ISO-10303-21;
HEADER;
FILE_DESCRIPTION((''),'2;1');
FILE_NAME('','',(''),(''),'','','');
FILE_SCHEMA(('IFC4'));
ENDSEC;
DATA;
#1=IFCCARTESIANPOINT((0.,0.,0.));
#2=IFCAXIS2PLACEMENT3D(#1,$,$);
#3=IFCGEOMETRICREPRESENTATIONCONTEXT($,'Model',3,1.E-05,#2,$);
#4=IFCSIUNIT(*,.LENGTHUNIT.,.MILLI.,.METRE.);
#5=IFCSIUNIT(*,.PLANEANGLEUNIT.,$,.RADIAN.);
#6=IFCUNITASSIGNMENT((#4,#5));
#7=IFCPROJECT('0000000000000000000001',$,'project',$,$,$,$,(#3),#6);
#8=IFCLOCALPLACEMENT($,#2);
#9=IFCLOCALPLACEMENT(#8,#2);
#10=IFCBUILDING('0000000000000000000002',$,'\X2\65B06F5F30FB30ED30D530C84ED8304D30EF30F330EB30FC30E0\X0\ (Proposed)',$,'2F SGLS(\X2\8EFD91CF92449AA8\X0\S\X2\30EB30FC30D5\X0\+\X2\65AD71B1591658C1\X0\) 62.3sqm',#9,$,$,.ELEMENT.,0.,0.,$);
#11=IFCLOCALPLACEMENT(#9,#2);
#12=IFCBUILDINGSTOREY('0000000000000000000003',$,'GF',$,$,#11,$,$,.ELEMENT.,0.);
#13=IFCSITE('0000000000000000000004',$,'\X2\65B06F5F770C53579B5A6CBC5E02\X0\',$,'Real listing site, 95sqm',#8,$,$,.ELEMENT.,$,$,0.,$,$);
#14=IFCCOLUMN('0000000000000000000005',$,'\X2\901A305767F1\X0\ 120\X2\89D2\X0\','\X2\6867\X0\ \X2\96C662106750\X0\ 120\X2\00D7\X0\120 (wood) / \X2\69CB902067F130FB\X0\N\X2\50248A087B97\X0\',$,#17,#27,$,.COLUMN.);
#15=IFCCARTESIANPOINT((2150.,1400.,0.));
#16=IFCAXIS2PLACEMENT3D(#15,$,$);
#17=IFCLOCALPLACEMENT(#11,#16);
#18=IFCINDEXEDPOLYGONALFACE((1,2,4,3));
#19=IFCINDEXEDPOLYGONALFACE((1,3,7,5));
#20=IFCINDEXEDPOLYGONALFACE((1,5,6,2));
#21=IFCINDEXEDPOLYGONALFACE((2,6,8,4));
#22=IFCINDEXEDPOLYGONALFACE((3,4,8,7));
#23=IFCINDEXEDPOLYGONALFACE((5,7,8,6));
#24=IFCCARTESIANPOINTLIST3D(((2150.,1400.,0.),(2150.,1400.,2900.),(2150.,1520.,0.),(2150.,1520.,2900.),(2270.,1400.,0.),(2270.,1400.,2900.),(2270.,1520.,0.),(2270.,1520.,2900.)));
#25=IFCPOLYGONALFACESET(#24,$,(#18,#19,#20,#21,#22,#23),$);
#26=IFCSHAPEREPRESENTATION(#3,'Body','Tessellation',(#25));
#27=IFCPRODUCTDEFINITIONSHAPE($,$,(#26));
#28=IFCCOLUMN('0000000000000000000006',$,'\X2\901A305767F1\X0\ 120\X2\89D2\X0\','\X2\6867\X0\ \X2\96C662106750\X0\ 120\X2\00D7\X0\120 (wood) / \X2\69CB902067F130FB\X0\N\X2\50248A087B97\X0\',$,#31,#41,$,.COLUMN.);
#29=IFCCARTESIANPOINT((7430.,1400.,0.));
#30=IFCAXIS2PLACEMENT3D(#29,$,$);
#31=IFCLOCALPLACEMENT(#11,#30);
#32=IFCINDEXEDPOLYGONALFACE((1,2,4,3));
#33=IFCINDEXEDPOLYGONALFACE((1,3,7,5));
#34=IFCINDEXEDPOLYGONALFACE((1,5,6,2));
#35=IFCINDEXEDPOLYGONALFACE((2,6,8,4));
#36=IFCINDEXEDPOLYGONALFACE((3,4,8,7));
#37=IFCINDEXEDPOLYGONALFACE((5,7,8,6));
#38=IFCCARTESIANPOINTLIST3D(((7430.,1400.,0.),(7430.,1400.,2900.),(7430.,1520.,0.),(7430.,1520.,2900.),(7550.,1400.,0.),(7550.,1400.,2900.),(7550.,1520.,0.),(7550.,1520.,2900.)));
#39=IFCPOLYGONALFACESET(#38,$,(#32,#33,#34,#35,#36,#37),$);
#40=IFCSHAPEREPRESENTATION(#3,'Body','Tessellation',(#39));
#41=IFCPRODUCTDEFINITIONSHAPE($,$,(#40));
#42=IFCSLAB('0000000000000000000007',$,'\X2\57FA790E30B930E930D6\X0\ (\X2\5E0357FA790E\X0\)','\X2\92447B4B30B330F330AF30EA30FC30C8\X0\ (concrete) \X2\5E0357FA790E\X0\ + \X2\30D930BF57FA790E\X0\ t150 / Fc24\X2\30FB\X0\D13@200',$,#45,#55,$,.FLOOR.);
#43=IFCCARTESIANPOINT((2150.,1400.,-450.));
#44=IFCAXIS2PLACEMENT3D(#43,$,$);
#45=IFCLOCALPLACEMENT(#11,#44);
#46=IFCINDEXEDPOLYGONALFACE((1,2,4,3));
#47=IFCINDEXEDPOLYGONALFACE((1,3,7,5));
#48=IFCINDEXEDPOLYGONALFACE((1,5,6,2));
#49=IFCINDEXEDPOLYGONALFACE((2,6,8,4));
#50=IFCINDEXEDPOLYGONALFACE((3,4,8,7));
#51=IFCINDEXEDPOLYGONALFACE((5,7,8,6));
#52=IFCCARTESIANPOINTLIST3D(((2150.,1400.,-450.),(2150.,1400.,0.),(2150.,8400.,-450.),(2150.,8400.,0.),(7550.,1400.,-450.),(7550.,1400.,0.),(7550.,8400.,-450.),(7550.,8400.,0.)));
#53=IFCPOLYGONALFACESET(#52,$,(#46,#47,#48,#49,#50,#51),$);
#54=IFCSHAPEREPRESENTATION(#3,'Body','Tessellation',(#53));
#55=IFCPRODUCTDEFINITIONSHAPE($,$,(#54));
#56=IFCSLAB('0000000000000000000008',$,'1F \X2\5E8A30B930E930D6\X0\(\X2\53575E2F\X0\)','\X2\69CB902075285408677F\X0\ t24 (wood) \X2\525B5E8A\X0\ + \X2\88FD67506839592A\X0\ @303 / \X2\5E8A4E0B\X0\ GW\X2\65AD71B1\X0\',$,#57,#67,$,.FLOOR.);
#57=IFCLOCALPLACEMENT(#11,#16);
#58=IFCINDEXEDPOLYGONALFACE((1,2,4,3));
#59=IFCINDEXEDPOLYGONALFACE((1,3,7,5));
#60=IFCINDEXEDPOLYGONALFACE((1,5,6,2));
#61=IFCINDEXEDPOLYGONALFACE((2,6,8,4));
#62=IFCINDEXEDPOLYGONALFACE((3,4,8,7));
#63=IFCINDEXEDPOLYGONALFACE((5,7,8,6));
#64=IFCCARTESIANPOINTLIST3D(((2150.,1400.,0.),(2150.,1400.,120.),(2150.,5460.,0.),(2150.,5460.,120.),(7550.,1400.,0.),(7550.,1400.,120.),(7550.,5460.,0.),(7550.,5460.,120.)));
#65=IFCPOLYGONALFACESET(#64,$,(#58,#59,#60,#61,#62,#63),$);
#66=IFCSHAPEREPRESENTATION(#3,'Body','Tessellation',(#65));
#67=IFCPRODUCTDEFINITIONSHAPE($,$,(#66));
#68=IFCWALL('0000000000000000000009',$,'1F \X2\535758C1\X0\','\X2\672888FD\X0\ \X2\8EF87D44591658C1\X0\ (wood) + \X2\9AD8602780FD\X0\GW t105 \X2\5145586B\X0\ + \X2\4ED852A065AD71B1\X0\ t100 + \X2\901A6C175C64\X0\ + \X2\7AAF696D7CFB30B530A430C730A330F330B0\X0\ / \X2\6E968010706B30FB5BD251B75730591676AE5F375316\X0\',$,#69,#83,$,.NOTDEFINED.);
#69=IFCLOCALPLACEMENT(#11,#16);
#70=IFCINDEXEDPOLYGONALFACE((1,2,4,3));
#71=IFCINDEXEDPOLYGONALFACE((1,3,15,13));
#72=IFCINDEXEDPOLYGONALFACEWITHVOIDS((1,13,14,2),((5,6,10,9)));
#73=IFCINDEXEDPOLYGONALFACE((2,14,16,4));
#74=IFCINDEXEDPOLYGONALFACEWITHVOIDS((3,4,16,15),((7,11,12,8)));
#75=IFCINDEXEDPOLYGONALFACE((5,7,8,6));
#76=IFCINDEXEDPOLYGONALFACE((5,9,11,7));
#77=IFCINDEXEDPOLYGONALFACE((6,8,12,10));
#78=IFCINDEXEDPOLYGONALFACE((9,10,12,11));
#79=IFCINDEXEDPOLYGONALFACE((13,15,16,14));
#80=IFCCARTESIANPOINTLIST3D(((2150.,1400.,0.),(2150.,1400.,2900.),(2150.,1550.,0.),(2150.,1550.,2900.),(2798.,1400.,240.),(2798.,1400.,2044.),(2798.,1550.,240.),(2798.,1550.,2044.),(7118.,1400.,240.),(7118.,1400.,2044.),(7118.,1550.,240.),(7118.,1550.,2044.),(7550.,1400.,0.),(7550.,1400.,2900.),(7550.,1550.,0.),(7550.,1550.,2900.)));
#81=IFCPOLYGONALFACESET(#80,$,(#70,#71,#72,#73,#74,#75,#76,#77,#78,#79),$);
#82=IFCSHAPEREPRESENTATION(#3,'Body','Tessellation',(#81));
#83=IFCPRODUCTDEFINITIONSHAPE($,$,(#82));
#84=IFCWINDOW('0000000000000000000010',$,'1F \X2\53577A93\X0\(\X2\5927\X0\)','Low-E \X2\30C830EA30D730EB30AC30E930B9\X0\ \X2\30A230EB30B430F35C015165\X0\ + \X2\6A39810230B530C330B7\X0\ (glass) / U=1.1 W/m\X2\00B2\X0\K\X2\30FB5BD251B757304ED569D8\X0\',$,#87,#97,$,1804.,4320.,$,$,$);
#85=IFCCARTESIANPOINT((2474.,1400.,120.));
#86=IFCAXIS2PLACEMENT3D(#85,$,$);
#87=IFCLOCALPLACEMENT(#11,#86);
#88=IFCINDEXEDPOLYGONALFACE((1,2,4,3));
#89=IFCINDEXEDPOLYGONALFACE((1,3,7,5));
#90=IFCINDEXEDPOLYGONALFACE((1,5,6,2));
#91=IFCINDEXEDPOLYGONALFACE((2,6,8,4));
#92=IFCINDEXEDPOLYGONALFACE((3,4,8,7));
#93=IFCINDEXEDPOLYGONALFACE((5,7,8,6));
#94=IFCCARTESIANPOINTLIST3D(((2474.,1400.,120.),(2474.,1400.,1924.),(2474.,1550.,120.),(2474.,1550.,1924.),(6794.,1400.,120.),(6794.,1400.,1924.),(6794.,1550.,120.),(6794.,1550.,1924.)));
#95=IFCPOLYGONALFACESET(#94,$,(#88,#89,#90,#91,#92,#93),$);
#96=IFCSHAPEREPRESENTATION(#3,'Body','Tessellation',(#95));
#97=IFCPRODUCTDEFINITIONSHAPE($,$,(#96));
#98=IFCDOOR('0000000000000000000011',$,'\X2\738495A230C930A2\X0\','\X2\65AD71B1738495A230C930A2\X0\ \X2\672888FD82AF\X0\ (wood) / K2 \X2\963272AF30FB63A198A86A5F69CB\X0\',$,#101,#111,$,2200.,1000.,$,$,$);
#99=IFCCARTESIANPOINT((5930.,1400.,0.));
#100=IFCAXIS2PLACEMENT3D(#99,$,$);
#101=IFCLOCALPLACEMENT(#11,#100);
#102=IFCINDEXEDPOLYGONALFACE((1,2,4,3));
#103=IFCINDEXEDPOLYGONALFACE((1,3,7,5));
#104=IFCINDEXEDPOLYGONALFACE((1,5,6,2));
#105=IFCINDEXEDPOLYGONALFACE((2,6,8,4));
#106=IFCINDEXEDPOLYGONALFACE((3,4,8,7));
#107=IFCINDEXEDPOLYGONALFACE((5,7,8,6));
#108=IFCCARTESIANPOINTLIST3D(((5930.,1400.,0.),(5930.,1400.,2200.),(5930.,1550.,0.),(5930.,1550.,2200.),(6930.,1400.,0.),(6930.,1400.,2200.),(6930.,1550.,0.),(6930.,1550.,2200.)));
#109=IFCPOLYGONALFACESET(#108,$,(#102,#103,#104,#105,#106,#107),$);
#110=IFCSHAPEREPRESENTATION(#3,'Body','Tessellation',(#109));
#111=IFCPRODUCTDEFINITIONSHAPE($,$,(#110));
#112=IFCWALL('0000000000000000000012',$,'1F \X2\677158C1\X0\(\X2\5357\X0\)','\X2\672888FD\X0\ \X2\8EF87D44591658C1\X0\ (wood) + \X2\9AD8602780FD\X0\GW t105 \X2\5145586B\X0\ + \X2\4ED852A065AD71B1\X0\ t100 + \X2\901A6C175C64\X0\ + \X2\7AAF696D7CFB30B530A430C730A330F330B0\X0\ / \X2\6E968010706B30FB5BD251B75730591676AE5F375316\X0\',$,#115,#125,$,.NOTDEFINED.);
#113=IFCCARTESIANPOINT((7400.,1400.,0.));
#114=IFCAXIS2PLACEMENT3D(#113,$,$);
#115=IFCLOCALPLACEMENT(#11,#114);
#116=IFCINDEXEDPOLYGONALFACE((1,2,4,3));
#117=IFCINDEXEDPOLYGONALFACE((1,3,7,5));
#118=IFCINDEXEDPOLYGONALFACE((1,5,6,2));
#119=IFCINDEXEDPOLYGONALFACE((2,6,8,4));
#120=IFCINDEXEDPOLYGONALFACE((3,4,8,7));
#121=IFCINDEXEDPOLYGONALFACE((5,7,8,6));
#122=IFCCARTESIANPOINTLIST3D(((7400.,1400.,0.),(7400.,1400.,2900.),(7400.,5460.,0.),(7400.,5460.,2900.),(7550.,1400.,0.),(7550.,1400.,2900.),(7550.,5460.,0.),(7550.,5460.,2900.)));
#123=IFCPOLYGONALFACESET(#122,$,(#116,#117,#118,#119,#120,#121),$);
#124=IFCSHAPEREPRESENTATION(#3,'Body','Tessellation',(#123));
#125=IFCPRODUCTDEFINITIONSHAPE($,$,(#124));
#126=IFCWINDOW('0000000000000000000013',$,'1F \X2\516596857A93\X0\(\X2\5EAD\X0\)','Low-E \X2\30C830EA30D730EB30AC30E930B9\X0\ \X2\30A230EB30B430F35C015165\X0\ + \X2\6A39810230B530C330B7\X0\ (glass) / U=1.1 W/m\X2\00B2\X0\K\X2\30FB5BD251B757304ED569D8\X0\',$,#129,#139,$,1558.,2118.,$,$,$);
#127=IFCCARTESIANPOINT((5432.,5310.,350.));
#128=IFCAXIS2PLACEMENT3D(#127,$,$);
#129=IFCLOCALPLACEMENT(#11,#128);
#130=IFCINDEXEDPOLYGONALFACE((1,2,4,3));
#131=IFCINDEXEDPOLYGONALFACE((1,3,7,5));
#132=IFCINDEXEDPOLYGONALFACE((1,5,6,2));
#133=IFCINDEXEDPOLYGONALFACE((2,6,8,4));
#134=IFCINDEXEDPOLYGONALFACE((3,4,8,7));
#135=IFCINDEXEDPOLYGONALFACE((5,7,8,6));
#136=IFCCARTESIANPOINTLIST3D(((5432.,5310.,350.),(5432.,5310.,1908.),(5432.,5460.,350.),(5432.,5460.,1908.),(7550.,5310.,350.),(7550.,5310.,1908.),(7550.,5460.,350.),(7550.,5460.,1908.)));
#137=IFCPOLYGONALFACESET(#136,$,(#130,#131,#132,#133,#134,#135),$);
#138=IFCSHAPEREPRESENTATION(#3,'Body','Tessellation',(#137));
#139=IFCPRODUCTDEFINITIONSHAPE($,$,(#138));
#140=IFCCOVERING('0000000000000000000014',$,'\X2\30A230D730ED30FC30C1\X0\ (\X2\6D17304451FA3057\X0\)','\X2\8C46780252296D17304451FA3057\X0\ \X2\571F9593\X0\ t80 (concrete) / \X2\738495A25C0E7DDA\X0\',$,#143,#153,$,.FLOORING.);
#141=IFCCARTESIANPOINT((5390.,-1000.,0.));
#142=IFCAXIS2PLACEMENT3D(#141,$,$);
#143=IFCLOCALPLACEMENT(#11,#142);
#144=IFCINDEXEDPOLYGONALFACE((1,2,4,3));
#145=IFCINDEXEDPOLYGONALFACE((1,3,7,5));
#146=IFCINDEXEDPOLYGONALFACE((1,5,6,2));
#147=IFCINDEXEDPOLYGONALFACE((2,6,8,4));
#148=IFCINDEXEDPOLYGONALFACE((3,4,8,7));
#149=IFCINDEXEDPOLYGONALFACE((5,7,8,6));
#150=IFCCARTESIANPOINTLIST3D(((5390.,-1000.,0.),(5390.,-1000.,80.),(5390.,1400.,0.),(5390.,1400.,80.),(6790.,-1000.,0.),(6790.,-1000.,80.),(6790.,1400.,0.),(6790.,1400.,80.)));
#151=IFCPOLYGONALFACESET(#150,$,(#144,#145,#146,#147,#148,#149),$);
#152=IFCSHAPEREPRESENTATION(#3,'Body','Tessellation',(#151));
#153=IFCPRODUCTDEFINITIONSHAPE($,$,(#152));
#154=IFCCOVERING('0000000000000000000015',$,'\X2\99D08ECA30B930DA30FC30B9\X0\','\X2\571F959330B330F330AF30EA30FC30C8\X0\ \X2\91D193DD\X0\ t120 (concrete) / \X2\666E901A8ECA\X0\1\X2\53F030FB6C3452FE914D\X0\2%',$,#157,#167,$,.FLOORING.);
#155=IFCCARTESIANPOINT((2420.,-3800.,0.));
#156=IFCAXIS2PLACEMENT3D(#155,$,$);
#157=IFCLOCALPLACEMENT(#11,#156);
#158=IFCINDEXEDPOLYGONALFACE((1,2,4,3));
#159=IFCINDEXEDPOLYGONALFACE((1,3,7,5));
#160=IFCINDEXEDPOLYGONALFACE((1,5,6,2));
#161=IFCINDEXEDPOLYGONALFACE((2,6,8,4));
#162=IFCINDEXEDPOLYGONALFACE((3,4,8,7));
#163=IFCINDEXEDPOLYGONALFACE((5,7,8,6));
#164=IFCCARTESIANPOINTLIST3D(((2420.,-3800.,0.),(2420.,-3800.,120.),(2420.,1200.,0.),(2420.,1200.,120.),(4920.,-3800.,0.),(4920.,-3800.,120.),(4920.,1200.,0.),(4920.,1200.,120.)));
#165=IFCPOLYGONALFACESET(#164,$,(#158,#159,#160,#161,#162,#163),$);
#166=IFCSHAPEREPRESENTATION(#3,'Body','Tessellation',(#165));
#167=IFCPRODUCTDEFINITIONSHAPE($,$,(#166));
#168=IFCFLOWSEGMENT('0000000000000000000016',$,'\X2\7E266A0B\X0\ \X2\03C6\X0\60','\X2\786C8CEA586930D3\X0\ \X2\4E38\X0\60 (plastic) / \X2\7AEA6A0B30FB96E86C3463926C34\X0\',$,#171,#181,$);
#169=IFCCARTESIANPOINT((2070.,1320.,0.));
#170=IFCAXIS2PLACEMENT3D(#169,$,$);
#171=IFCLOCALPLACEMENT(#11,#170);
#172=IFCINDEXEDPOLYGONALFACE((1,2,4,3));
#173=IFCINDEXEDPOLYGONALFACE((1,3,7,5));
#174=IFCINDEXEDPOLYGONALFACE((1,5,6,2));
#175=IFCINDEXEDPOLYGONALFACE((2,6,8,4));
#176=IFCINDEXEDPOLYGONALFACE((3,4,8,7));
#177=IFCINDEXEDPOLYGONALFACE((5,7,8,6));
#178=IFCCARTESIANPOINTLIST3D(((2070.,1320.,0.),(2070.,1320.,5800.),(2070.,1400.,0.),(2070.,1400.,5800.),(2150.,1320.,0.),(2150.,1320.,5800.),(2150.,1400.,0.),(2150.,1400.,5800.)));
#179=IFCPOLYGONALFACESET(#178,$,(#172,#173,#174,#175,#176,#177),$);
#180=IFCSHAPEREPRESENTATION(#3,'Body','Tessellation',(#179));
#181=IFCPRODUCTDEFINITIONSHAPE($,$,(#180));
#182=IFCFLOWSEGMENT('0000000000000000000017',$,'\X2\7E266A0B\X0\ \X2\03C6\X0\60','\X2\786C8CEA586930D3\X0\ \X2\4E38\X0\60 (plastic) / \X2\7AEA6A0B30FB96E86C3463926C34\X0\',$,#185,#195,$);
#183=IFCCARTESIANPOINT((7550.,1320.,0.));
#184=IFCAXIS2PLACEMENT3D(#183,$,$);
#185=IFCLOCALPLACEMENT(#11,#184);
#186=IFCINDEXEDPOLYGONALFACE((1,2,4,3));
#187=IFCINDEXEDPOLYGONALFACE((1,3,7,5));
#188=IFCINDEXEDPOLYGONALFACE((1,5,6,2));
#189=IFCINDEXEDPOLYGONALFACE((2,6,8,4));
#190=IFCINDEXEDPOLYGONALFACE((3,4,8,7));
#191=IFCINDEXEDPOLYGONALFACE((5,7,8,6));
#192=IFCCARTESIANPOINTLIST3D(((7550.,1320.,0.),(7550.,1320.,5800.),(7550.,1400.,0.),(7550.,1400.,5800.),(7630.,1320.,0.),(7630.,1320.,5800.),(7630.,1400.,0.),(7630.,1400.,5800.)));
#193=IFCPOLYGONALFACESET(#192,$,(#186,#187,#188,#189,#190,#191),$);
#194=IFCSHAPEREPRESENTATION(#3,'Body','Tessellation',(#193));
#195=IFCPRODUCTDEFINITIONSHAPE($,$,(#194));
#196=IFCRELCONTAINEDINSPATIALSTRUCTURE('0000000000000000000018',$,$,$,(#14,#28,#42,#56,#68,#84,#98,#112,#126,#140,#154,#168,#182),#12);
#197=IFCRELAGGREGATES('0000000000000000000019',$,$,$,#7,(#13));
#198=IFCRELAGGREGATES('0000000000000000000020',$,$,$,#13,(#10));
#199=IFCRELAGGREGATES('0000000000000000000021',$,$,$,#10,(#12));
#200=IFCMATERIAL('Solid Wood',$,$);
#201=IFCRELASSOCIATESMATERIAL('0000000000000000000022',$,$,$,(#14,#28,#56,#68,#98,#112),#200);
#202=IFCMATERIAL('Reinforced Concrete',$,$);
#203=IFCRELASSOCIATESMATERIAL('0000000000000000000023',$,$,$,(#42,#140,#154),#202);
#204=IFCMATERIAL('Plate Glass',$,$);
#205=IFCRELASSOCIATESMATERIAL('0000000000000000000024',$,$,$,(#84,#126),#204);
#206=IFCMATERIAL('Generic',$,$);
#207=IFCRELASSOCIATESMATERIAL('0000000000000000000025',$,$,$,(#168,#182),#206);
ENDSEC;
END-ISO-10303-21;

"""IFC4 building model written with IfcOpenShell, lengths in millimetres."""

from ifc_helpers import new_model, si_unit, frame, frame_2d, origin, place, context, project, spatial, rectangle, extrude, material, element, fill, save


model = new_model("IFC4")

# Units and contexts
model_context = context("Model", 3, precision=1e-05, world=origin())
ifc_project = project(units=[si_unit("LENGTHUNIT", "METRE", prefix="MILLI"), si_unit("PLANEANGLEUNIT", "RADIAN")], contexts=[model_context])

# Site, building, storey
site_placement = place(None, origin())
site = spatial("IfcSite", under=ifc_project, at=site_placement, Name="新潟県南魚沼市", ObjectType="Real listing site, 95sqm", CompositionType="ELEMENT", RefElevation=0.0)
building_placement = place(site_placement, origin())
building = spatial("IfcBuilding", under=site, at=building_placement, Name="新潟・ロフト付きワンルーム (Proposed)", ObjectType="2F SGLS(軽量鉄骨Sルーフ+断熱外壁) 62.3sqm", CompositionType="ELEMENT", ElevationOfRefHeight=0.0, ElevationOfTerrain=0.0)
storey_placement = place(building_placement, origin())
storey = spatial("IfcBuildingStorey", under=building, at=storey_placement, Name="GF", CompositionType="ELEMENT", Elevation=0.0)

# Columns
ifc_material_1 = material(Name="Solid Wood")
column_1_placement = place(storey_placement, frame((2150.0, 1400.0, 0.0)))
element("IfcColumn", 1, at=column_1_placement, inside=storey, material=ifc_material_1, Name="通し柱 120角", Description="桧 集成材 120×120 (wood) / 構造柱・N値計算", PredefinedType="COLUMN", context=model_context, shape_type="SweptSolid", body=[
    extrude(rectangle(XDim=120.0, YDim=120.0, at=frame_2d((60.0, 60.0))), frame((2150.0, 1400.0, 0.0)), (0.0, 0.0, 1.0), 2900.0),
])
column_2_placement = place(storey_placement, frame((7430.0, 1400.0, 0.0)))
element("IfcColumn", 2, at=column_2_placement, inside=storey, material=ifc_material_1, Name="通し柱 120角", Description="桧 集成材 120×120 (wood) / 構造柱・N値計算", PredefinedType="COLUMN", context=model_context, shape_type="SweptSolid", body=[
    extrude(rectangle(XDim=120.0, YDim=120.0, at=frame_2d((60.0, 60.0))), frame((7430.0, 1400.0, 0.0)), (0.0, 0.0, 1.0), 2900.0),
])

# Slabs
ifc_material_2 = material(Name="Reinforced Concrete")
slab_1_placement = place(storey_placement, frame((2150.0, 1400.0, -450.0)))
element("IfcSlab", 3, at=slab_1_placement, inside=storey, material=ifc_material_2, Name="基礎スラブ (布基礎)", Description="鉄筋コンクリート (concrete) 布基礎 + ベタ基礎 t150 / Fc24・D13@200", PredefinedType="FLOOR", context=model_context, shape_type="SweptSolid", body=[
    extrude(rectangle(XDim=5400.0, YDim=7000.0, at=frame_2d((2700.0, 3500.0))), frame((2150.0, 1400.0, -450.0)), (0.0, 0.0, 1.0), 450.0),
])
slab_2_placement = place(storey_placement, frame((2150.0, 1400.0, 0.0)))
element("IfcSlab", 4, at=slab_2_placement, inside=storey, material=ifc_material_1, Name="1F 床スラブ(南帯)", Description="構造用合板 t24 (wood) 剛床 + 製材根太 @303 / 床下 GW断熱", PredefinedType="FLOOR", context=model_context, shape_type="SweptSolid", body=[
    extrude(rectangle(XDim=5400.0, YDim=4060.0, at=frame_2d((2700.0, 2030.0))), frame((2150.0, 1400.0, 0.0)), (0.0, 0.0, 1.0), 120.0),
])

# Wall, openings, window, door
wall_1_placement = place(storey_placement, frame((2150.0, 1400.0, 0.0)))
wall_1 = element("IfcWall", 5, at=wall_1_placement, inside=storey, material=ifc_material_1, Name="1F 南壁", Description="木製 軸組外壁 (wood) + 高性能GW t105 充填 + 付加断熱 t100 + 通気層 + 窯業系サイディング / 準耐火・寒冷地外皮強化", PredefinedType="NOTDEFINED", context=model_context, shape_type="SweptSolid", body=[
    extrude(rectangle(XDim=5400.0, YDim=150.0, at=frame_2d((2700.0, 75.0))), frame((2150.0, 1400.0, 0.0)), (0.0, 0.0, 1.0), 2900.0),
])
opening_1_placement = place(storey_placement, frame((2474.0, 1400.0, 120.0)))
opening_1 = element("IfcOpeningElement", 6, at=opening_1_placement, cuts=wall_1, PredefinedType="NOTDEFINED", context=model_context, shape_type="SweptSolid", body=[
    extrude(rectangle(XDim=4320.0, YDim=150.0, at=frame_2d((2160.0, 75.0))), frame((2474.0, 1400.0, 120.0)), (0.0, 0.0, 1.0), 1804.0),
])
opening_2_placement = place(storey_placement, frame((5930.0, 1400.0, 0.0)))
opening_2 = element("IfcOpeningElement", 7, at=opening_2_placement, cuts=wall_1, PredefinedType="NOTDEFINED", context=model_context, shape_type="SweptSolid", body=[
    extrude(rectangle(XDim=1000.0, YDim=150.0, at=frame_2d((500.0, 75.0))), frame((5930.0, 1400.0, 0.0)), (0.0, 0.0, 1.0), 2200.0),
])
ifc_material_3 = material(Name="Plate Glass")
window_1_placement = place(storey_placement, frame((2474.0, 1400.0, 120.0)))
window_1 = element("IfcWindow", 8, at=window_1_placement, inside=storey, material=ifc_material_3, Name="1F 南窓(大)", Description="Low-E トリプルガラス アルゴン封入 + 樹脂サッシ (glass) / U=1.1 W/m²K・寒冷地仕様", OverallHeight=1804.0, OverallWidth=4320.0, context=model_context, shape_type="SweptSolid", body=[
    extrude(rectangle(XDim=4320.0, YDim=150.0, at=frame_2d((2160.0, 75.0))), frame((2474.0, 1400.0, 120.0)), (0.0, 0.0, 1.0), 1804.0),
])
fill(opening_1, window_1)
door_1_placement = place(storey_placement, frame((5930.0, 1400.0, 0.0)))
door_1 = element("IfcDoor", 9, at=door_1_placement, inside=storey, material=ifc_material_1, Name="玄関ドア", Description="断熱玄関ドア 木製芯 (wood) / K2 防犯・採風機構", OverallHeight=2200.0, OverallWidth=1000.0, context=model_context, shape_type="SweptSolid", body=[
    extrude(rectangle(XDim=1000.0, YDim=150.0, at=frame_2d((500.0, 75.0))), frame((5930.0, 1400.0, 0.0)), (0.0, 0.0, 1.0), 2200.0),
])
fill(opening_2, door_1)

# Wall, opening, window
wall_2_placement = place(storey_placement, frame((7400.0, 1400.0, 0.0)))
wall_2 = element("IfcWall", 10, at=wall_2_placement, inside=storey, material=ifc_material_1, Name="1F 東壁(南)", Description="木製 軸組外壁 (wood) + 高性能GW t105 充填 + 付加断熱 t100 + 通気層 + 窯業系サイディング / 準耐火・寒冷地外皮強化", PredefinedType="NOTDEFINED", context=model_context, shape_type="SweptSolid", body=[
    extrude(rectangle(XDim=150.0, YDim=4060.0, at=frame_2d((75.0, 2030.0))), frame((7400.0, 1400.0, 0.0)), (0.0, 0.0, 1.0), 2900.0),
])
opening_3_placement = place(storey_placement, frame((5432.0, 5310.0, 350.0)))
opening_3 = element("IfcOpeningElement", 11, at=opening_3_placement, cuts=wall_2, PredefinedType="NOTDEFINED", context=model_context, shape_type="SweptSolid", body=[
    extrude(rectangle(XDim=2118.0, YDim=150.0, at=frame_2d((1059.0, 75.0))), frame((5432.0, 5310.0, 350.0)), (0.0, 0.0, 1.0), 1558.0),
])
window_2_placement = place(storey_placement, frame((5432.0, 5310.0, 350.0)))
window_2 = element("IfcWindow", 12, at=window_2_placement, inside=storey, material=ifc_material_3, Name="1F 入隅窓(庭)", Description="Low-E トリプルガラス アルゴン封入 + 樹脂サッシ (glass) / U=1.1 W/m²K・寒冷地仕様", OverallHeight=1558.0, OverallWidth=2118.0, context=model_context, shape_type="SweptSolid", body=[
    extrude(rectangle(XDim=2118.0, YDim=150.0, at=frame_2d((1059.0, 75.0))), frame((5432.0, 5310.0, 350.0)), (0.0, 0.0, 1.0), 1558.0),
])
fill(opening_3, window_2)

# Coverings
covering_1_placement = place(storey_placement, frame((5390.0, -1000.0, 0.0)))
element("IfcCovering", 13, at=covering_1_placement, inside=storey, material=ifc_material_2, Name="アプローチ (洗い出し)", Description="豆砂利洗い出し 土間 t80 (concrete) / 玄関導線", PredefinedType="FLOORING", context=model_context, shape_type="SweptSolid", body=[
    extrude(rectangle(XDim=1400.0, YDim=2400.0, at=frame_2d((700.0, 1200.0))), frame((5390.0, -1000.0, 0.0)), (0.0, 0.0, 1.0), 80.0),
])
covering_2_placement = place(storey_placement, frame((2420.0, -3800.0, 0.0)))
element("IfcCovering", 14, at=covering_2_placement, inside=storey, material=ifc_material_2, Name="駐車スペース", Description="土間コンクリート 金鏝 t120 (concrete) / 普通車1台・水勾配2%", PredefinedType="FLOORING", context=model_context, shape_type="SweptSolid", body=[
    extrude(rectangle(XDim=2500.0, YDim=5000.0, at=frame_2d((1250.0, 2500.0))), frame((2420.0, -3800.0, 0.0)), (0.0, 0.0, 1.0), 120.0),
])

# Flow segments
ifc_material_4 = material(Name="Generic")
flow_segment_1_placement = place(storey_placement, frame((2070.0, 1320.0, 0.0)))
element("IfcFlowSegment", 15, at=flow_segment_1_placement, inside=storey, material=ifc_material_4, Name="縦樋 φ60", Description="硬質塩ビ 丸60 (plastic) / 竪樋・雨水排水", context=model_context, shape_type="SweptSolid", body=[
    extrude(rectangle(XDim=80.0, YDim=80.0, at=frame_2d((40.0, 40.0))), frame((2070.0, 1320.0, 0.0)), (0.0, 0.0, 1.0), 5800.0),
])
flow_segment_2_placement = place(storey_placement, frame((7550.0, 1320.0, 0.0)))
element("IfcFlowSegment", 16, at=flow_segment_2_placement, inside=storey, material=ifc_material_4, Name="縦樋 φ60", Description="硬質塩ビ 丸60 (plastic) / 竪樋・雨水排水", context=model_context, shape_type="SweptSolid", body=[
    extrude(rectangle(XDim=80.0, YDim=80.0, at=frame_2d((40.0, 40.0))), frame((7550.0, 1320.0, 0.0)), (0.0, 0.0, 1.0), 5800.0),
])

save(model, "model.ifc")
